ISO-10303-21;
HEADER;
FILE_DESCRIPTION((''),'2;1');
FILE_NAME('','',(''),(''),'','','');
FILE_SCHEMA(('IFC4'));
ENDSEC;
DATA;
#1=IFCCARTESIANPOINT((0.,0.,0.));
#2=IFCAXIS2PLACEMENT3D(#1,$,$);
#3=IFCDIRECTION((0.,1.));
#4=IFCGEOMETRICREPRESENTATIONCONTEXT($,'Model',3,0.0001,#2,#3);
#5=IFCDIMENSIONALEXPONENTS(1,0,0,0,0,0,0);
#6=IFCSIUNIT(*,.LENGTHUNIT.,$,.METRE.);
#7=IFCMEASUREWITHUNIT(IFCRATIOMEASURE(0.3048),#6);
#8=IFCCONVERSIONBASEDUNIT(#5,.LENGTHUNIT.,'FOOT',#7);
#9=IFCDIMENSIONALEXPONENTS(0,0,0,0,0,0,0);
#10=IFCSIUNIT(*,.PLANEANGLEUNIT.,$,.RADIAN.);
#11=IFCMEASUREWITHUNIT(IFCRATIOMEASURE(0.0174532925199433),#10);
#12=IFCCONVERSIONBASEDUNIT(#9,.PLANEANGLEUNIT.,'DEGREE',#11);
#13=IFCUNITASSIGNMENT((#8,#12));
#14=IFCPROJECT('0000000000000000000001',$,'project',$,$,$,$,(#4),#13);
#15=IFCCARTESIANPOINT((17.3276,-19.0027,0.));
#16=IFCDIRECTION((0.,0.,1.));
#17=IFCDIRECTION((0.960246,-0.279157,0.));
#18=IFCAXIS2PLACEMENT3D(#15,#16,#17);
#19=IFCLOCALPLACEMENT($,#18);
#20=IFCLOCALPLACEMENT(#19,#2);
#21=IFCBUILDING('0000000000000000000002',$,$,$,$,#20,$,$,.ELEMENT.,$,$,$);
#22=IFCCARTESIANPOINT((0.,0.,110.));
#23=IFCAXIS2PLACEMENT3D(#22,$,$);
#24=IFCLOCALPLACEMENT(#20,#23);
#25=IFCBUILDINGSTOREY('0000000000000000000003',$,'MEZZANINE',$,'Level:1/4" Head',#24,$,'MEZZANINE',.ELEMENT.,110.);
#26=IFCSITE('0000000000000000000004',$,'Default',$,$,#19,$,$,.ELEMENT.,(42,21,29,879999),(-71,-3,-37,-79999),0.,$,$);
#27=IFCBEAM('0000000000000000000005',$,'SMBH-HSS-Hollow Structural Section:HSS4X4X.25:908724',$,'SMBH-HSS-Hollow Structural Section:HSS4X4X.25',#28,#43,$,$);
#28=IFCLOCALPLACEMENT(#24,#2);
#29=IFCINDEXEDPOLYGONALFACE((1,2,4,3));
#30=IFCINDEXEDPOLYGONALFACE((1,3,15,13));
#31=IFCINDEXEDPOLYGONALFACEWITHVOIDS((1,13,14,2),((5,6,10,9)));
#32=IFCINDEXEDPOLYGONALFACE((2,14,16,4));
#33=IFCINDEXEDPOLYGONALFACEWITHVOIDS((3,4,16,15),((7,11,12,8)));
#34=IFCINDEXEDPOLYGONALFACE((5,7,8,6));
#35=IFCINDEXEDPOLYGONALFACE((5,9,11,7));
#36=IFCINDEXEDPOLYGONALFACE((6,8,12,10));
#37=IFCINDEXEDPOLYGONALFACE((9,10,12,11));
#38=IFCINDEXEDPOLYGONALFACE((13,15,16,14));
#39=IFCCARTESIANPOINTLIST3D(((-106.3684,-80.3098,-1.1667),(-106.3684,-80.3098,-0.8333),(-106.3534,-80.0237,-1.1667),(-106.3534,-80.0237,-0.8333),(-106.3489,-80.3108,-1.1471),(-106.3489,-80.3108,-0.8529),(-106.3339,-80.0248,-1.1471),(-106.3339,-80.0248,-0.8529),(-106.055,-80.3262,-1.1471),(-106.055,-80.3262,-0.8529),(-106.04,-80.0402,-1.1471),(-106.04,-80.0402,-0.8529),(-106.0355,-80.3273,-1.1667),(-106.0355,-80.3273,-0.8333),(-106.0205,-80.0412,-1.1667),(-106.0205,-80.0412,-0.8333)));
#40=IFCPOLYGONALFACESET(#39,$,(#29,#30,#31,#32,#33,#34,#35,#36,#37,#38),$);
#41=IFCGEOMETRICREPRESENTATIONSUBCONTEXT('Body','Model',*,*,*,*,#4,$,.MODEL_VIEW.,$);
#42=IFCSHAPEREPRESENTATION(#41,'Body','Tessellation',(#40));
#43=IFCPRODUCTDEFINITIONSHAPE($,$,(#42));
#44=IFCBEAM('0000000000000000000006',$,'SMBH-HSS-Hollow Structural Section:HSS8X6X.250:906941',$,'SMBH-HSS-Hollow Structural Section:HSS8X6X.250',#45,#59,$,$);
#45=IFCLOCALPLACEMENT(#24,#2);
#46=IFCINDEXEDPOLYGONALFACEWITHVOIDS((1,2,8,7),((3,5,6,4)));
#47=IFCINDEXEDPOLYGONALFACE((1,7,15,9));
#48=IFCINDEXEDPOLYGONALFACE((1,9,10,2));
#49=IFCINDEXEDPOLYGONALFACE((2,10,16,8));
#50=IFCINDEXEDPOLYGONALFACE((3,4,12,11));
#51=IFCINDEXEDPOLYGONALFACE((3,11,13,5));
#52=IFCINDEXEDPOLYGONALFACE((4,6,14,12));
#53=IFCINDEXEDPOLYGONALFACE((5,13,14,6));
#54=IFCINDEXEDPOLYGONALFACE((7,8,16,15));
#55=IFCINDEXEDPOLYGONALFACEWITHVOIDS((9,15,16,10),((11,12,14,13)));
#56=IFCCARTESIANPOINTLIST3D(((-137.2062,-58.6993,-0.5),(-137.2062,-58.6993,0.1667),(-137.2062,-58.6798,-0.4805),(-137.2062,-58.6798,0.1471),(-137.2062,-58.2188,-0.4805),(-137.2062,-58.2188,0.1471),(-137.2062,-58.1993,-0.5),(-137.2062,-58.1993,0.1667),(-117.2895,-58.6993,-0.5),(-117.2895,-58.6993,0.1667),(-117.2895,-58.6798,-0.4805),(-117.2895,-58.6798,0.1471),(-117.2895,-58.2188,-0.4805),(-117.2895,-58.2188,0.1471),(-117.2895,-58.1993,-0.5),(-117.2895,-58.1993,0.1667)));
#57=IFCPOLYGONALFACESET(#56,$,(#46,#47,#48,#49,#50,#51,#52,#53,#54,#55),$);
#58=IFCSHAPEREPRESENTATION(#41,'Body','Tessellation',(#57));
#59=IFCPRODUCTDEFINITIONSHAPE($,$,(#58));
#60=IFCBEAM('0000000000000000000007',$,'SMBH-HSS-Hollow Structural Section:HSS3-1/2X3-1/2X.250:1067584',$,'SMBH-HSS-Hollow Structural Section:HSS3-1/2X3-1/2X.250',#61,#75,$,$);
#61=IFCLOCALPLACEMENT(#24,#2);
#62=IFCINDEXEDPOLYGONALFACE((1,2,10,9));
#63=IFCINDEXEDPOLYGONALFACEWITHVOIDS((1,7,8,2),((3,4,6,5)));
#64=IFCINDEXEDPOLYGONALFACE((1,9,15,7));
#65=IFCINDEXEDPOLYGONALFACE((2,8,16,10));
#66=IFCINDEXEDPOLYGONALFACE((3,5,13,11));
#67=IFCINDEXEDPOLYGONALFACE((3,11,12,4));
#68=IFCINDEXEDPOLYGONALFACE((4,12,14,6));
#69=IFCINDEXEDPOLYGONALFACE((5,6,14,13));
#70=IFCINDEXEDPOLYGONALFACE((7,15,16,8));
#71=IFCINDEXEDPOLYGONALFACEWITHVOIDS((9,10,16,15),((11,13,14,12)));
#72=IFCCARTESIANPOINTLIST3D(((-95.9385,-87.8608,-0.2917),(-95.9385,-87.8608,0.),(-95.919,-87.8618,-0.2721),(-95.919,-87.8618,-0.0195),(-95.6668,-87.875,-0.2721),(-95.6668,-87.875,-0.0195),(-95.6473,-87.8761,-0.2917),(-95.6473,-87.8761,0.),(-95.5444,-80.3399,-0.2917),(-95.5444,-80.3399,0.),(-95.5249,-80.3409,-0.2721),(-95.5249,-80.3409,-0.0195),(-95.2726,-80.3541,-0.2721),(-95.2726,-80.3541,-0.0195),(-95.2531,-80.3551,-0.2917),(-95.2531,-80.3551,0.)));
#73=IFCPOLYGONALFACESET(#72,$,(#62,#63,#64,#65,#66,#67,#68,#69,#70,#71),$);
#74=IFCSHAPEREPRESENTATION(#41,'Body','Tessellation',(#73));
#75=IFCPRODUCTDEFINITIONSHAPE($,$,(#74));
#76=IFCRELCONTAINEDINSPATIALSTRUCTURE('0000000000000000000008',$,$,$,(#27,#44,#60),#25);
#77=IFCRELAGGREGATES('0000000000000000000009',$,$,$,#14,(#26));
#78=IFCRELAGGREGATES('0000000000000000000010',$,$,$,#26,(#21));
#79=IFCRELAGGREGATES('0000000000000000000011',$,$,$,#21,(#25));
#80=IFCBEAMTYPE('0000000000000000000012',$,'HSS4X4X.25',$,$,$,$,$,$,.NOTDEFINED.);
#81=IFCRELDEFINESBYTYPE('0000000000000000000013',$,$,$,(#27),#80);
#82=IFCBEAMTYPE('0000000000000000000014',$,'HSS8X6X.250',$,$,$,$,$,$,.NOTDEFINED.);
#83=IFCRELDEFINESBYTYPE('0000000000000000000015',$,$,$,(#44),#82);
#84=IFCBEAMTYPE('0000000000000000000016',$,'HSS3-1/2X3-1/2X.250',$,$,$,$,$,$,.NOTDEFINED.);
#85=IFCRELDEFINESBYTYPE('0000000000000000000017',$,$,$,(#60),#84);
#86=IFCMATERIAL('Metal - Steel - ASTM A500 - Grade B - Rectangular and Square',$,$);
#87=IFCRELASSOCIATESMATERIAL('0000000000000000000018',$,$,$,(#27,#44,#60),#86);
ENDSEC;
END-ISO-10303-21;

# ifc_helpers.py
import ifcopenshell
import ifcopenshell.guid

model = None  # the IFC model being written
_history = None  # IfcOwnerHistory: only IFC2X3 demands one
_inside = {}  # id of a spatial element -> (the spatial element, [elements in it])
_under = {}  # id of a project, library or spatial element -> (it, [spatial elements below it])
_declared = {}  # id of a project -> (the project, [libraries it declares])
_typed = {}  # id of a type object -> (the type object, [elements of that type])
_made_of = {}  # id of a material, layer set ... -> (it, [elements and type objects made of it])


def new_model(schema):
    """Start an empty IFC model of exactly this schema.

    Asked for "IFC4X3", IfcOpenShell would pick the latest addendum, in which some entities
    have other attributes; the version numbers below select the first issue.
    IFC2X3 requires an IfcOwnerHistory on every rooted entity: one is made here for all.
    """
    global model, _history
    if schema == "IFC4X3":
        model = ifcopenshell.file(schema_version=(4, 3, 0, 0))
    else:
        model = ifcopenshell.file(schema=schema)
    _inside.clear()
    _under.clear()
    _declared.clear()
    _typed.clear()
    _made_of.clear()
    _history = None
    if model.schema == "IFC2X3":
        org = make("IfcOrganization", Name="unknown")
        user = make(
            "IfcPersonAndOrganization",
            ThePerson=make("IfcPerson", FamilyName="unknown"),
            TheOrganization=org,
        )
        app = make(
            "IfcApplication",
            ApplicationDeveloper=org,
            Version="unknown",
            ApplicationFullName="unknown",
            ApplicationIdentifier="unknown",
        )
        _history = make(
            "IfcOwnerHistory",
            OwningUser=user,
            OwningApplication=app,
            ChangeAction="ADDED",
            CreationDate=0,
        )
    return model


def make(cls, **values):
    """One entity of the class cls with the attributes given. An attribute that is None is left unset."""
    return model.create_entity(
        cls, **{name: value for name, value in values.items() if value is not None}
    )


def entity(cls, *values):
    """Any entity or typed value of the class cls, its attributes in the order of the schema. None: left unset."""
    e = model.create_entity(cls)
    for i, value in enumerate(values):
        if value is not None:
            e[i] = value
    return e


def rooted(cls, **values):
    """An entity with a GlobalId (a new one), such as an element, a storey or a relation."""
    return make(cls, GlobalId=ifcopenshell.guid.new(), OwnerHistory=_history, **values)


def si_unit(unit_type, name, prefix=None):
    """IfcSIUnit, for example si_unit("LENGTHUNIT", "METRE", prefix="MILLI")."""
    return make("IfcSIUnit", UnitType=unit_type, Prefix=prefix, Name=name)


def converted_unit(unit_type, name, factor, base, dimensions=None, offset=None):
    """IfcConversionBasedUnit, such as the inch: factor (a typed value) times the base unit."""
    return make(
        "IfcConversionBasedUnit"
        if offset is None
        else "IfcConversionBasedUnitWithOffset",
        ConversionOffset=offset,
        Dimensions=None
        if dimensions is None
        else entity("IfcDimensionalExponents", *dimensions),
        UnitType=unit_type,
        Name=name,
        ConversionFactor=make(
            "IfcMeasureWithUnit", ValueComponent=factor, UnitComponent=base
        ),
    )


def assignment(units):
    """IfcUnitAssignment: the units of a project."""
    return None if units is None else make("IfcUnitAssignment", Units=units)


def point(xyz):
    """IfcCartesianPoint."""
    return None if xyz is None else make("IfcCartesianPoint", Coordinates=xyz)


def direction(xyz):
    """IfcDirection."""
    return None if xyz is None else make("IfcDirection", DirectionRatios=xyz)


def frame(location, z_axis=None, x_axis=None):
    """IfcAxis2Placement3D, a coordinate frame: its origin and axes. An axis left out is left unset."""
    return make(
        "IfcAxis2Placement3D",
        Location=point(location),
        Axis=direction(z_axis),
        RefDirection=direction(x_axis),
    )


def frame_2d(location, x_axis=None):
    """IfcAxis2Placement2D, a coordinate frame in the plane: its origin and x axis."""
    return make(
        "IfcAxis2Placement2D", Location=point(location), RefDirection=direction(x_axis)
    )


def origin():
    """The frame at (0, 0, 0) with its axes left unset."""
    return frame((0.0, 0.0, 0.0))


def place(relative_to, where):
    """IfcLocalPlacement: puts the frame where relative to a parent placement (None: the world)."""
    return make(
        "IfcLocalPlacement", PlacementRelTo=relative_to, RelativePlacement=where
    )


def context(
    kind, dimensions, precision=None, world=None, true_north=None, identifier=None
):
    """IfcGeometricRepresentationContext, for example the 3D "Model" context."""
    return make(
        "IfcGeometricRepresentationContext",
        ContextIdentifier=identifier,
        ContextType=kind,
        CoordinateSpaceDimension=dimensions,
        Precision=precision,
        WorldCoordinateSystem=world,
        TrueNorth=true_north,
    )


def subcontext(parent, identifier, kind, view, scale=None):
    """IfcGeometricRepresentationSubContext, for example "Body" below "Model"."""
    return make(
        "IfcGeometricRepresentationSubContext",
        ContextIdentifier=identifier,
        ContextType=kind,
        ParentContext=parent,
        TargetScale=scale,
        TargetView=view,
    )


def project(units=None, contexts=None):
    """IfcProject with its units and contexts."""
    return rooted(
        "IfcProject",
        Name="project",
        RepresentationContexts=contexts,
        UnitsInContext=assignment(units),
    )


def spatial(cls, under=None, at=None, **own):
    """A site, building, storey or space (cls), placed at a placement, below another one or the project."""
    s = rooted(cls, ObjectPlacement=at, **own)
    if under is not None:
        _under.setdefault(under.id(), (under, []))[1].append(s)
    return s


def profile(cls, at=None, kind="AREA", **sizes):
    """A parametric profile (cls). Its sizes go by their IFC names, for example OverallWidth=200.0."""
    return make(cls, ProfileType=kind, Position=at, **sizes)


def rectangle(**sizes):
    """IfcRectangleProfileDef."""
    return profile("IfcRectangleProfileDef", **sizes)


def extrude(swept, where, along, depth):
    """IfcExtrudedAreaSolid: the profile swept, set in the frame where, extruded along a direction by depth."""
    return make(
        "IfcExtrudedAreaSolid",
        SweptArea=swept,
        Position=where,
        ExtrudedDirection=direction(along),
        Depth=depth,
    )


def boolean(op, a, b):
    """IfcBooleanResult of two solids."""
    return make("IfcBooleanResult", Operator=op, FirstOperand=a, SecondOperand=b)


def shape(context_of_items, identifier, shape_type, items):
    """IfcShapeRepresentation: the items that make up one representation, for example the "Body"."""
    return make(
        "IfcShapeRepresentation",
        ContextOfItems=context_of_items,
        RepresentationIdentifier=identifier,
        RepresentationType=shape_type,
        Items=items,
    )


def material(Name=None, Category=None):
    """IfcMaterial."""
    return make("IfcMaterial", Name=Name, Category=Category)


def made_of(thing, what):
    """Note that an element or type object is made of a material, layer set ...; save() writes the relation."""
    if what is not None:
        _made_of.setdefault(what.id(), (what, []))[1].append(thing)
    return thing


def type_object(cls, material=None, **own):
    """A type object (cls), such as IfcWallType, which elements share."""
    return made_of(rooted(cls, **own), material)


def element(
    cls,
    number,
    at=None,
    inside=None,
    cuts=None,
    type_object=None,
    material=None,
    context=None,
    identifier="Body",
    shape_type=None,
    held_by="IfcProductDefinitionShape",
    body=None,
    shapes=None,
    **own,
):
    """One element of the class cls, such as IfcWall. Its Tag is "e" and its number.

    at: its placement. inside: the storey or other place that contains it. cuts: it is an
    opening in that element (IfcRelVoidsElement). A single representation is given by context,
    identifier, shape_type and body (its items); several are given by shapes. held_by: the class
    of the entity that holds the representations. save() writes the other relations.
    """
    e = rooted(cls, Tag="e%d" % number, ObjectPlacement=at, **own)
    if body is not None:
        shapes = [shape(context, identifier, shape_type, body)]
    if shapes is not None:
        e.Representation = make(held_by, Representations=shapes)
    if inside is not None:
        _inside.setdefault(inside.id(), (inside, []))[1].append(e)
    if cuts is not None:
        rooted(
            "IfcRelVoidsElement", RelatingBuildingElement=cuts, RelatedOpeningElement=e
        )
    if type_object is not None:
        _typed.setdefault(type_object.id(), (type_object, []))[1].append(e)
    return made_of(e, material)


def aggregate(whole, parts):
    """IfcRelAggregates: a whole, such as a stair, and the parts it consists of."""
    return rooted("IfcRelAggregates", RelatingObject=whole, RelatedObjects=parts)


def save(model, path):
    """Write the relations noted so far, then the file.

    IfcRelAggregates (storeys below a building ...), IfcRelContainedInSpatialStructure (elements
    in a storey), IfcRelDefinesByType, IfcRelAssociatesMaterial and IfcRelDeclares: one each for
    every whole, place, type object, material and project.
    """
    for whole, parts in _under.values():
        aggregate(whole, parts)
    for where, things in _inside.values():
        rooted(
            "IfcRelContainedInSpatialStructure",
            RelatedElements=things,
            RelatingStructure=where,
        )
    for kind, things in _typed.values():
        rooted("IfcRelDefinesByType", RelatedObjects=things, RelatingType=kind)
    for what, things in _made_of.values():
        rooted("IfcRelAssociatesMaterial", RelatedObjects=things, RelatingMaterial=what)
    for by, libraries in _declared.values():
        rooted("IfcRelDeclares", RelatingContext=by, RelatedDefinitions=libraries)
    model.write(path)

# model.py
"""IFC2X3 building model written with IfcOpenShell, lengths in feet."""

from ifc_helpers import new_model, entity, si_unit, converted_unit, direction, frame, frame_2d, origin, place, context, subcontext, project, spatial, rectangle, extrude, boolean, material, type_object, element, save


model = new_model("IFC2X3")

# Units and contexts
model_context = context("Model", 3, precision=0.0001, world=origin(), true_north=direction((0.0, 1.0)))
body_context = subcontext(model_context, "Body", "Model", "MODEL_VIEW")
ifc_project = project(units=[converted_unit("LENGTHUNIT", "FOOT", entity("IfcRatioMeasure", 0.3048), si_unit("LENGTHUNIT", "METRE"), dimensions=[1, 0, 0, 0, 0, 0, 0]), converted_unit("PLANEANGLEUNIT", "DEGREE", entity("IfcRatioMeasure", 0.0174532925199433), si_unit("PLANEANGLEUNIT", "RADIAN"), dimensions=[0, 0, 0, 0, 0, 0, 0])], contexts=[model_context])

# Site, building, storey
site_placement = place(None, frame((17.3276, -19.0027, 0.0), z_axis=(0.0, 0.0, 1.0), x_axis=(0.960246, -0.279157, 0.0)))
site = spatial("IfcSite", under=ifc_project, at=site_placement, Name="Default", CompositionType="ELEMENT", RefLatitude=(42, 21, 29, 879999), RefLongitude=(-71, -3, -37, -79999), RefElevation=0.0)
building_placement = place(site_placement, origin())
building = spatial("IfcBuilding", under=site, at=building_placement, CompositionType="ELEMENT")
storey_placement = place(building_placement, frame((0.0, 0.0, 110.0)))
storey = spatial("IfcBuildingStorey", under=building, at=storey_placement, Name="MEZZANINE", ObjectType="Level:1/4\" Head", LongName="MEZZANINE", CompositionType="ELEMENT", Elevation=110.0)

# Beams
ifc_material_1 = material(Name="Metal - Steel - ASTM A500 - Grade B - Rectangular and Square")
beam_type_1 = type_object("IfcBeamType", Name="HSS4X4X.25", PredefinedType="NOTDEFINED")
beam_1_placement = place(storey_placement, frame((-106.2019, -80.3185, -0.8333), z_axis=(0.0, 0.0, 1.0), x_axis=(0.052336, 0.99863, 0.0)))
element("IfcBeam", 1, at=beam_1_placement, inside=storey, type_object=beam_type_1, material=ifc_material_1, Name="SMBH-HSS-Hollow Structural Section:HSS4X4X.25:908724", ObjectType="SMBH-HSS-Hollow Structural Section:HSS4X4X.25", context=body_context, shape_type="SweptSolid", body=[
    boolean("DIFFERENCE", extrude(rectangle(XDim=0.3333, YDim=0.3333, at=frame_2d((0.0, 0.0), x_axis=(1.0, 0.0))), frame((0.0, 0.0, -0.1667), z_axis=(1.0, 0.0, 0.0), x_axis=(0.0, 0.0, -1.0)), (0.0, 0.0, 1.0), 0.2865), extrude(rectangle(XDim=0.2943, YDim=0.2943, at=frame_2d((0.0, 0.0), x_axis=(0.0, 1.0))), frame((0.2865, 0.0, -0.1667), z_axis=(-1.0, 0.0, 0.0), x_axis=(0.0, 1.0, 0.0)), (0.0, 0.0, 1.0), 0.2865)),
])
beam_type_2 = type_object("IfcBeamType", Name="HSS8X6X.250", PredefinedType="NOTDEFINED")
beam_2_placement = place(storey_placement, frame((-137.8312, -58.4493, 0.1667)))
element("IfcBeam", 2, at=beam_2_placement, inside=storey, type_object=beam_type_2, material=ifc_material_1, Name="SMBH-HSS-Hollow Structural Section:HSS8X6X.250:906941", ObjectType="SMBH-HSS-Hollow Structural Section:HSS8X6X.250", context=body_context, shape_type="SweptSolid", body=[
    boolean("DIFFERENCE", extrude(rectangle(XDim=0.6667, YDim=0.5, at=frame_2d((0.0, 0.0), x_axis=(1.0, 0.0))), frame((0.625, 0.0, -0.3333), z_axis=(1.0, 0.0, 0.0), x_axis=(0.0, 0.0, -1.0)), (0.0, 0.0, 1.0), 19.9167), extrude(rectangle(XDim=0.6276, YDim=0.4609, at=frame_2d((0.0, 0.0), x_axis=(0.0, 1.0))), frame((20.5417, 0.0, -0.3333), z_axis=(-1.0, 0.0, 0.0), x_axis=(0.0, 1.0, 0.0)), (0.0, 0.0, 1.0), 19.9167)),
])
beam_type_3 = type_object("IfcBeamType", Name="HSS3-1/2X3-1/2X.250", PredefinedType="NOTDEFINED")
beam_3_placement = place(storey_placement, frame((-95.8082, -88.1597, 0.0), z_axis=(0.0, 0.0, 1.0), x_axis=(0.052336, 0.99863, 0.0)))
element("IfcBeam", 3, at=beam_3_placement, inside=storey, type_object=beam_type_3, material=ifc_material_1, Name="SMBH-HSS-Hollow Structural Section:HSS3-1/2X3-1/2X.250:1067584", ObjectType="SMBH-HSS-Hollow Structural Section:HSS3-1/2X3-1/2X.250", context=body_context, shape_type="SweptSolid", body=[
    boolean("DIFFERENCE", extrude(rectangle(XDim=0.2917, YDim=0.2917, at=frame_2d((0.0, 0.0), x_axis=(1.0, 0.0))), frame((0.2917, 0.0, -0.1458), z_axis=(1.0, 0.0, 0.0), x_axis=(0.0, 0.0, -1.0)), (0.0, 0.0, 1.0), 7.5312), extrude(rectangle(XDim=0.2526, YDim=0.2526, at=frame_2d((0.0, 0.0), x_axis=(0.0, 1.0))), frame((7.8229, 0.0, -0.1458), z_axis=(-1.0, 0.0, 0.0), x_axis=(0.0, 1.0, 0.0)), (0.0, 0.0, 1.0), 7.5312)),
])

save(model, "model.ifc")
